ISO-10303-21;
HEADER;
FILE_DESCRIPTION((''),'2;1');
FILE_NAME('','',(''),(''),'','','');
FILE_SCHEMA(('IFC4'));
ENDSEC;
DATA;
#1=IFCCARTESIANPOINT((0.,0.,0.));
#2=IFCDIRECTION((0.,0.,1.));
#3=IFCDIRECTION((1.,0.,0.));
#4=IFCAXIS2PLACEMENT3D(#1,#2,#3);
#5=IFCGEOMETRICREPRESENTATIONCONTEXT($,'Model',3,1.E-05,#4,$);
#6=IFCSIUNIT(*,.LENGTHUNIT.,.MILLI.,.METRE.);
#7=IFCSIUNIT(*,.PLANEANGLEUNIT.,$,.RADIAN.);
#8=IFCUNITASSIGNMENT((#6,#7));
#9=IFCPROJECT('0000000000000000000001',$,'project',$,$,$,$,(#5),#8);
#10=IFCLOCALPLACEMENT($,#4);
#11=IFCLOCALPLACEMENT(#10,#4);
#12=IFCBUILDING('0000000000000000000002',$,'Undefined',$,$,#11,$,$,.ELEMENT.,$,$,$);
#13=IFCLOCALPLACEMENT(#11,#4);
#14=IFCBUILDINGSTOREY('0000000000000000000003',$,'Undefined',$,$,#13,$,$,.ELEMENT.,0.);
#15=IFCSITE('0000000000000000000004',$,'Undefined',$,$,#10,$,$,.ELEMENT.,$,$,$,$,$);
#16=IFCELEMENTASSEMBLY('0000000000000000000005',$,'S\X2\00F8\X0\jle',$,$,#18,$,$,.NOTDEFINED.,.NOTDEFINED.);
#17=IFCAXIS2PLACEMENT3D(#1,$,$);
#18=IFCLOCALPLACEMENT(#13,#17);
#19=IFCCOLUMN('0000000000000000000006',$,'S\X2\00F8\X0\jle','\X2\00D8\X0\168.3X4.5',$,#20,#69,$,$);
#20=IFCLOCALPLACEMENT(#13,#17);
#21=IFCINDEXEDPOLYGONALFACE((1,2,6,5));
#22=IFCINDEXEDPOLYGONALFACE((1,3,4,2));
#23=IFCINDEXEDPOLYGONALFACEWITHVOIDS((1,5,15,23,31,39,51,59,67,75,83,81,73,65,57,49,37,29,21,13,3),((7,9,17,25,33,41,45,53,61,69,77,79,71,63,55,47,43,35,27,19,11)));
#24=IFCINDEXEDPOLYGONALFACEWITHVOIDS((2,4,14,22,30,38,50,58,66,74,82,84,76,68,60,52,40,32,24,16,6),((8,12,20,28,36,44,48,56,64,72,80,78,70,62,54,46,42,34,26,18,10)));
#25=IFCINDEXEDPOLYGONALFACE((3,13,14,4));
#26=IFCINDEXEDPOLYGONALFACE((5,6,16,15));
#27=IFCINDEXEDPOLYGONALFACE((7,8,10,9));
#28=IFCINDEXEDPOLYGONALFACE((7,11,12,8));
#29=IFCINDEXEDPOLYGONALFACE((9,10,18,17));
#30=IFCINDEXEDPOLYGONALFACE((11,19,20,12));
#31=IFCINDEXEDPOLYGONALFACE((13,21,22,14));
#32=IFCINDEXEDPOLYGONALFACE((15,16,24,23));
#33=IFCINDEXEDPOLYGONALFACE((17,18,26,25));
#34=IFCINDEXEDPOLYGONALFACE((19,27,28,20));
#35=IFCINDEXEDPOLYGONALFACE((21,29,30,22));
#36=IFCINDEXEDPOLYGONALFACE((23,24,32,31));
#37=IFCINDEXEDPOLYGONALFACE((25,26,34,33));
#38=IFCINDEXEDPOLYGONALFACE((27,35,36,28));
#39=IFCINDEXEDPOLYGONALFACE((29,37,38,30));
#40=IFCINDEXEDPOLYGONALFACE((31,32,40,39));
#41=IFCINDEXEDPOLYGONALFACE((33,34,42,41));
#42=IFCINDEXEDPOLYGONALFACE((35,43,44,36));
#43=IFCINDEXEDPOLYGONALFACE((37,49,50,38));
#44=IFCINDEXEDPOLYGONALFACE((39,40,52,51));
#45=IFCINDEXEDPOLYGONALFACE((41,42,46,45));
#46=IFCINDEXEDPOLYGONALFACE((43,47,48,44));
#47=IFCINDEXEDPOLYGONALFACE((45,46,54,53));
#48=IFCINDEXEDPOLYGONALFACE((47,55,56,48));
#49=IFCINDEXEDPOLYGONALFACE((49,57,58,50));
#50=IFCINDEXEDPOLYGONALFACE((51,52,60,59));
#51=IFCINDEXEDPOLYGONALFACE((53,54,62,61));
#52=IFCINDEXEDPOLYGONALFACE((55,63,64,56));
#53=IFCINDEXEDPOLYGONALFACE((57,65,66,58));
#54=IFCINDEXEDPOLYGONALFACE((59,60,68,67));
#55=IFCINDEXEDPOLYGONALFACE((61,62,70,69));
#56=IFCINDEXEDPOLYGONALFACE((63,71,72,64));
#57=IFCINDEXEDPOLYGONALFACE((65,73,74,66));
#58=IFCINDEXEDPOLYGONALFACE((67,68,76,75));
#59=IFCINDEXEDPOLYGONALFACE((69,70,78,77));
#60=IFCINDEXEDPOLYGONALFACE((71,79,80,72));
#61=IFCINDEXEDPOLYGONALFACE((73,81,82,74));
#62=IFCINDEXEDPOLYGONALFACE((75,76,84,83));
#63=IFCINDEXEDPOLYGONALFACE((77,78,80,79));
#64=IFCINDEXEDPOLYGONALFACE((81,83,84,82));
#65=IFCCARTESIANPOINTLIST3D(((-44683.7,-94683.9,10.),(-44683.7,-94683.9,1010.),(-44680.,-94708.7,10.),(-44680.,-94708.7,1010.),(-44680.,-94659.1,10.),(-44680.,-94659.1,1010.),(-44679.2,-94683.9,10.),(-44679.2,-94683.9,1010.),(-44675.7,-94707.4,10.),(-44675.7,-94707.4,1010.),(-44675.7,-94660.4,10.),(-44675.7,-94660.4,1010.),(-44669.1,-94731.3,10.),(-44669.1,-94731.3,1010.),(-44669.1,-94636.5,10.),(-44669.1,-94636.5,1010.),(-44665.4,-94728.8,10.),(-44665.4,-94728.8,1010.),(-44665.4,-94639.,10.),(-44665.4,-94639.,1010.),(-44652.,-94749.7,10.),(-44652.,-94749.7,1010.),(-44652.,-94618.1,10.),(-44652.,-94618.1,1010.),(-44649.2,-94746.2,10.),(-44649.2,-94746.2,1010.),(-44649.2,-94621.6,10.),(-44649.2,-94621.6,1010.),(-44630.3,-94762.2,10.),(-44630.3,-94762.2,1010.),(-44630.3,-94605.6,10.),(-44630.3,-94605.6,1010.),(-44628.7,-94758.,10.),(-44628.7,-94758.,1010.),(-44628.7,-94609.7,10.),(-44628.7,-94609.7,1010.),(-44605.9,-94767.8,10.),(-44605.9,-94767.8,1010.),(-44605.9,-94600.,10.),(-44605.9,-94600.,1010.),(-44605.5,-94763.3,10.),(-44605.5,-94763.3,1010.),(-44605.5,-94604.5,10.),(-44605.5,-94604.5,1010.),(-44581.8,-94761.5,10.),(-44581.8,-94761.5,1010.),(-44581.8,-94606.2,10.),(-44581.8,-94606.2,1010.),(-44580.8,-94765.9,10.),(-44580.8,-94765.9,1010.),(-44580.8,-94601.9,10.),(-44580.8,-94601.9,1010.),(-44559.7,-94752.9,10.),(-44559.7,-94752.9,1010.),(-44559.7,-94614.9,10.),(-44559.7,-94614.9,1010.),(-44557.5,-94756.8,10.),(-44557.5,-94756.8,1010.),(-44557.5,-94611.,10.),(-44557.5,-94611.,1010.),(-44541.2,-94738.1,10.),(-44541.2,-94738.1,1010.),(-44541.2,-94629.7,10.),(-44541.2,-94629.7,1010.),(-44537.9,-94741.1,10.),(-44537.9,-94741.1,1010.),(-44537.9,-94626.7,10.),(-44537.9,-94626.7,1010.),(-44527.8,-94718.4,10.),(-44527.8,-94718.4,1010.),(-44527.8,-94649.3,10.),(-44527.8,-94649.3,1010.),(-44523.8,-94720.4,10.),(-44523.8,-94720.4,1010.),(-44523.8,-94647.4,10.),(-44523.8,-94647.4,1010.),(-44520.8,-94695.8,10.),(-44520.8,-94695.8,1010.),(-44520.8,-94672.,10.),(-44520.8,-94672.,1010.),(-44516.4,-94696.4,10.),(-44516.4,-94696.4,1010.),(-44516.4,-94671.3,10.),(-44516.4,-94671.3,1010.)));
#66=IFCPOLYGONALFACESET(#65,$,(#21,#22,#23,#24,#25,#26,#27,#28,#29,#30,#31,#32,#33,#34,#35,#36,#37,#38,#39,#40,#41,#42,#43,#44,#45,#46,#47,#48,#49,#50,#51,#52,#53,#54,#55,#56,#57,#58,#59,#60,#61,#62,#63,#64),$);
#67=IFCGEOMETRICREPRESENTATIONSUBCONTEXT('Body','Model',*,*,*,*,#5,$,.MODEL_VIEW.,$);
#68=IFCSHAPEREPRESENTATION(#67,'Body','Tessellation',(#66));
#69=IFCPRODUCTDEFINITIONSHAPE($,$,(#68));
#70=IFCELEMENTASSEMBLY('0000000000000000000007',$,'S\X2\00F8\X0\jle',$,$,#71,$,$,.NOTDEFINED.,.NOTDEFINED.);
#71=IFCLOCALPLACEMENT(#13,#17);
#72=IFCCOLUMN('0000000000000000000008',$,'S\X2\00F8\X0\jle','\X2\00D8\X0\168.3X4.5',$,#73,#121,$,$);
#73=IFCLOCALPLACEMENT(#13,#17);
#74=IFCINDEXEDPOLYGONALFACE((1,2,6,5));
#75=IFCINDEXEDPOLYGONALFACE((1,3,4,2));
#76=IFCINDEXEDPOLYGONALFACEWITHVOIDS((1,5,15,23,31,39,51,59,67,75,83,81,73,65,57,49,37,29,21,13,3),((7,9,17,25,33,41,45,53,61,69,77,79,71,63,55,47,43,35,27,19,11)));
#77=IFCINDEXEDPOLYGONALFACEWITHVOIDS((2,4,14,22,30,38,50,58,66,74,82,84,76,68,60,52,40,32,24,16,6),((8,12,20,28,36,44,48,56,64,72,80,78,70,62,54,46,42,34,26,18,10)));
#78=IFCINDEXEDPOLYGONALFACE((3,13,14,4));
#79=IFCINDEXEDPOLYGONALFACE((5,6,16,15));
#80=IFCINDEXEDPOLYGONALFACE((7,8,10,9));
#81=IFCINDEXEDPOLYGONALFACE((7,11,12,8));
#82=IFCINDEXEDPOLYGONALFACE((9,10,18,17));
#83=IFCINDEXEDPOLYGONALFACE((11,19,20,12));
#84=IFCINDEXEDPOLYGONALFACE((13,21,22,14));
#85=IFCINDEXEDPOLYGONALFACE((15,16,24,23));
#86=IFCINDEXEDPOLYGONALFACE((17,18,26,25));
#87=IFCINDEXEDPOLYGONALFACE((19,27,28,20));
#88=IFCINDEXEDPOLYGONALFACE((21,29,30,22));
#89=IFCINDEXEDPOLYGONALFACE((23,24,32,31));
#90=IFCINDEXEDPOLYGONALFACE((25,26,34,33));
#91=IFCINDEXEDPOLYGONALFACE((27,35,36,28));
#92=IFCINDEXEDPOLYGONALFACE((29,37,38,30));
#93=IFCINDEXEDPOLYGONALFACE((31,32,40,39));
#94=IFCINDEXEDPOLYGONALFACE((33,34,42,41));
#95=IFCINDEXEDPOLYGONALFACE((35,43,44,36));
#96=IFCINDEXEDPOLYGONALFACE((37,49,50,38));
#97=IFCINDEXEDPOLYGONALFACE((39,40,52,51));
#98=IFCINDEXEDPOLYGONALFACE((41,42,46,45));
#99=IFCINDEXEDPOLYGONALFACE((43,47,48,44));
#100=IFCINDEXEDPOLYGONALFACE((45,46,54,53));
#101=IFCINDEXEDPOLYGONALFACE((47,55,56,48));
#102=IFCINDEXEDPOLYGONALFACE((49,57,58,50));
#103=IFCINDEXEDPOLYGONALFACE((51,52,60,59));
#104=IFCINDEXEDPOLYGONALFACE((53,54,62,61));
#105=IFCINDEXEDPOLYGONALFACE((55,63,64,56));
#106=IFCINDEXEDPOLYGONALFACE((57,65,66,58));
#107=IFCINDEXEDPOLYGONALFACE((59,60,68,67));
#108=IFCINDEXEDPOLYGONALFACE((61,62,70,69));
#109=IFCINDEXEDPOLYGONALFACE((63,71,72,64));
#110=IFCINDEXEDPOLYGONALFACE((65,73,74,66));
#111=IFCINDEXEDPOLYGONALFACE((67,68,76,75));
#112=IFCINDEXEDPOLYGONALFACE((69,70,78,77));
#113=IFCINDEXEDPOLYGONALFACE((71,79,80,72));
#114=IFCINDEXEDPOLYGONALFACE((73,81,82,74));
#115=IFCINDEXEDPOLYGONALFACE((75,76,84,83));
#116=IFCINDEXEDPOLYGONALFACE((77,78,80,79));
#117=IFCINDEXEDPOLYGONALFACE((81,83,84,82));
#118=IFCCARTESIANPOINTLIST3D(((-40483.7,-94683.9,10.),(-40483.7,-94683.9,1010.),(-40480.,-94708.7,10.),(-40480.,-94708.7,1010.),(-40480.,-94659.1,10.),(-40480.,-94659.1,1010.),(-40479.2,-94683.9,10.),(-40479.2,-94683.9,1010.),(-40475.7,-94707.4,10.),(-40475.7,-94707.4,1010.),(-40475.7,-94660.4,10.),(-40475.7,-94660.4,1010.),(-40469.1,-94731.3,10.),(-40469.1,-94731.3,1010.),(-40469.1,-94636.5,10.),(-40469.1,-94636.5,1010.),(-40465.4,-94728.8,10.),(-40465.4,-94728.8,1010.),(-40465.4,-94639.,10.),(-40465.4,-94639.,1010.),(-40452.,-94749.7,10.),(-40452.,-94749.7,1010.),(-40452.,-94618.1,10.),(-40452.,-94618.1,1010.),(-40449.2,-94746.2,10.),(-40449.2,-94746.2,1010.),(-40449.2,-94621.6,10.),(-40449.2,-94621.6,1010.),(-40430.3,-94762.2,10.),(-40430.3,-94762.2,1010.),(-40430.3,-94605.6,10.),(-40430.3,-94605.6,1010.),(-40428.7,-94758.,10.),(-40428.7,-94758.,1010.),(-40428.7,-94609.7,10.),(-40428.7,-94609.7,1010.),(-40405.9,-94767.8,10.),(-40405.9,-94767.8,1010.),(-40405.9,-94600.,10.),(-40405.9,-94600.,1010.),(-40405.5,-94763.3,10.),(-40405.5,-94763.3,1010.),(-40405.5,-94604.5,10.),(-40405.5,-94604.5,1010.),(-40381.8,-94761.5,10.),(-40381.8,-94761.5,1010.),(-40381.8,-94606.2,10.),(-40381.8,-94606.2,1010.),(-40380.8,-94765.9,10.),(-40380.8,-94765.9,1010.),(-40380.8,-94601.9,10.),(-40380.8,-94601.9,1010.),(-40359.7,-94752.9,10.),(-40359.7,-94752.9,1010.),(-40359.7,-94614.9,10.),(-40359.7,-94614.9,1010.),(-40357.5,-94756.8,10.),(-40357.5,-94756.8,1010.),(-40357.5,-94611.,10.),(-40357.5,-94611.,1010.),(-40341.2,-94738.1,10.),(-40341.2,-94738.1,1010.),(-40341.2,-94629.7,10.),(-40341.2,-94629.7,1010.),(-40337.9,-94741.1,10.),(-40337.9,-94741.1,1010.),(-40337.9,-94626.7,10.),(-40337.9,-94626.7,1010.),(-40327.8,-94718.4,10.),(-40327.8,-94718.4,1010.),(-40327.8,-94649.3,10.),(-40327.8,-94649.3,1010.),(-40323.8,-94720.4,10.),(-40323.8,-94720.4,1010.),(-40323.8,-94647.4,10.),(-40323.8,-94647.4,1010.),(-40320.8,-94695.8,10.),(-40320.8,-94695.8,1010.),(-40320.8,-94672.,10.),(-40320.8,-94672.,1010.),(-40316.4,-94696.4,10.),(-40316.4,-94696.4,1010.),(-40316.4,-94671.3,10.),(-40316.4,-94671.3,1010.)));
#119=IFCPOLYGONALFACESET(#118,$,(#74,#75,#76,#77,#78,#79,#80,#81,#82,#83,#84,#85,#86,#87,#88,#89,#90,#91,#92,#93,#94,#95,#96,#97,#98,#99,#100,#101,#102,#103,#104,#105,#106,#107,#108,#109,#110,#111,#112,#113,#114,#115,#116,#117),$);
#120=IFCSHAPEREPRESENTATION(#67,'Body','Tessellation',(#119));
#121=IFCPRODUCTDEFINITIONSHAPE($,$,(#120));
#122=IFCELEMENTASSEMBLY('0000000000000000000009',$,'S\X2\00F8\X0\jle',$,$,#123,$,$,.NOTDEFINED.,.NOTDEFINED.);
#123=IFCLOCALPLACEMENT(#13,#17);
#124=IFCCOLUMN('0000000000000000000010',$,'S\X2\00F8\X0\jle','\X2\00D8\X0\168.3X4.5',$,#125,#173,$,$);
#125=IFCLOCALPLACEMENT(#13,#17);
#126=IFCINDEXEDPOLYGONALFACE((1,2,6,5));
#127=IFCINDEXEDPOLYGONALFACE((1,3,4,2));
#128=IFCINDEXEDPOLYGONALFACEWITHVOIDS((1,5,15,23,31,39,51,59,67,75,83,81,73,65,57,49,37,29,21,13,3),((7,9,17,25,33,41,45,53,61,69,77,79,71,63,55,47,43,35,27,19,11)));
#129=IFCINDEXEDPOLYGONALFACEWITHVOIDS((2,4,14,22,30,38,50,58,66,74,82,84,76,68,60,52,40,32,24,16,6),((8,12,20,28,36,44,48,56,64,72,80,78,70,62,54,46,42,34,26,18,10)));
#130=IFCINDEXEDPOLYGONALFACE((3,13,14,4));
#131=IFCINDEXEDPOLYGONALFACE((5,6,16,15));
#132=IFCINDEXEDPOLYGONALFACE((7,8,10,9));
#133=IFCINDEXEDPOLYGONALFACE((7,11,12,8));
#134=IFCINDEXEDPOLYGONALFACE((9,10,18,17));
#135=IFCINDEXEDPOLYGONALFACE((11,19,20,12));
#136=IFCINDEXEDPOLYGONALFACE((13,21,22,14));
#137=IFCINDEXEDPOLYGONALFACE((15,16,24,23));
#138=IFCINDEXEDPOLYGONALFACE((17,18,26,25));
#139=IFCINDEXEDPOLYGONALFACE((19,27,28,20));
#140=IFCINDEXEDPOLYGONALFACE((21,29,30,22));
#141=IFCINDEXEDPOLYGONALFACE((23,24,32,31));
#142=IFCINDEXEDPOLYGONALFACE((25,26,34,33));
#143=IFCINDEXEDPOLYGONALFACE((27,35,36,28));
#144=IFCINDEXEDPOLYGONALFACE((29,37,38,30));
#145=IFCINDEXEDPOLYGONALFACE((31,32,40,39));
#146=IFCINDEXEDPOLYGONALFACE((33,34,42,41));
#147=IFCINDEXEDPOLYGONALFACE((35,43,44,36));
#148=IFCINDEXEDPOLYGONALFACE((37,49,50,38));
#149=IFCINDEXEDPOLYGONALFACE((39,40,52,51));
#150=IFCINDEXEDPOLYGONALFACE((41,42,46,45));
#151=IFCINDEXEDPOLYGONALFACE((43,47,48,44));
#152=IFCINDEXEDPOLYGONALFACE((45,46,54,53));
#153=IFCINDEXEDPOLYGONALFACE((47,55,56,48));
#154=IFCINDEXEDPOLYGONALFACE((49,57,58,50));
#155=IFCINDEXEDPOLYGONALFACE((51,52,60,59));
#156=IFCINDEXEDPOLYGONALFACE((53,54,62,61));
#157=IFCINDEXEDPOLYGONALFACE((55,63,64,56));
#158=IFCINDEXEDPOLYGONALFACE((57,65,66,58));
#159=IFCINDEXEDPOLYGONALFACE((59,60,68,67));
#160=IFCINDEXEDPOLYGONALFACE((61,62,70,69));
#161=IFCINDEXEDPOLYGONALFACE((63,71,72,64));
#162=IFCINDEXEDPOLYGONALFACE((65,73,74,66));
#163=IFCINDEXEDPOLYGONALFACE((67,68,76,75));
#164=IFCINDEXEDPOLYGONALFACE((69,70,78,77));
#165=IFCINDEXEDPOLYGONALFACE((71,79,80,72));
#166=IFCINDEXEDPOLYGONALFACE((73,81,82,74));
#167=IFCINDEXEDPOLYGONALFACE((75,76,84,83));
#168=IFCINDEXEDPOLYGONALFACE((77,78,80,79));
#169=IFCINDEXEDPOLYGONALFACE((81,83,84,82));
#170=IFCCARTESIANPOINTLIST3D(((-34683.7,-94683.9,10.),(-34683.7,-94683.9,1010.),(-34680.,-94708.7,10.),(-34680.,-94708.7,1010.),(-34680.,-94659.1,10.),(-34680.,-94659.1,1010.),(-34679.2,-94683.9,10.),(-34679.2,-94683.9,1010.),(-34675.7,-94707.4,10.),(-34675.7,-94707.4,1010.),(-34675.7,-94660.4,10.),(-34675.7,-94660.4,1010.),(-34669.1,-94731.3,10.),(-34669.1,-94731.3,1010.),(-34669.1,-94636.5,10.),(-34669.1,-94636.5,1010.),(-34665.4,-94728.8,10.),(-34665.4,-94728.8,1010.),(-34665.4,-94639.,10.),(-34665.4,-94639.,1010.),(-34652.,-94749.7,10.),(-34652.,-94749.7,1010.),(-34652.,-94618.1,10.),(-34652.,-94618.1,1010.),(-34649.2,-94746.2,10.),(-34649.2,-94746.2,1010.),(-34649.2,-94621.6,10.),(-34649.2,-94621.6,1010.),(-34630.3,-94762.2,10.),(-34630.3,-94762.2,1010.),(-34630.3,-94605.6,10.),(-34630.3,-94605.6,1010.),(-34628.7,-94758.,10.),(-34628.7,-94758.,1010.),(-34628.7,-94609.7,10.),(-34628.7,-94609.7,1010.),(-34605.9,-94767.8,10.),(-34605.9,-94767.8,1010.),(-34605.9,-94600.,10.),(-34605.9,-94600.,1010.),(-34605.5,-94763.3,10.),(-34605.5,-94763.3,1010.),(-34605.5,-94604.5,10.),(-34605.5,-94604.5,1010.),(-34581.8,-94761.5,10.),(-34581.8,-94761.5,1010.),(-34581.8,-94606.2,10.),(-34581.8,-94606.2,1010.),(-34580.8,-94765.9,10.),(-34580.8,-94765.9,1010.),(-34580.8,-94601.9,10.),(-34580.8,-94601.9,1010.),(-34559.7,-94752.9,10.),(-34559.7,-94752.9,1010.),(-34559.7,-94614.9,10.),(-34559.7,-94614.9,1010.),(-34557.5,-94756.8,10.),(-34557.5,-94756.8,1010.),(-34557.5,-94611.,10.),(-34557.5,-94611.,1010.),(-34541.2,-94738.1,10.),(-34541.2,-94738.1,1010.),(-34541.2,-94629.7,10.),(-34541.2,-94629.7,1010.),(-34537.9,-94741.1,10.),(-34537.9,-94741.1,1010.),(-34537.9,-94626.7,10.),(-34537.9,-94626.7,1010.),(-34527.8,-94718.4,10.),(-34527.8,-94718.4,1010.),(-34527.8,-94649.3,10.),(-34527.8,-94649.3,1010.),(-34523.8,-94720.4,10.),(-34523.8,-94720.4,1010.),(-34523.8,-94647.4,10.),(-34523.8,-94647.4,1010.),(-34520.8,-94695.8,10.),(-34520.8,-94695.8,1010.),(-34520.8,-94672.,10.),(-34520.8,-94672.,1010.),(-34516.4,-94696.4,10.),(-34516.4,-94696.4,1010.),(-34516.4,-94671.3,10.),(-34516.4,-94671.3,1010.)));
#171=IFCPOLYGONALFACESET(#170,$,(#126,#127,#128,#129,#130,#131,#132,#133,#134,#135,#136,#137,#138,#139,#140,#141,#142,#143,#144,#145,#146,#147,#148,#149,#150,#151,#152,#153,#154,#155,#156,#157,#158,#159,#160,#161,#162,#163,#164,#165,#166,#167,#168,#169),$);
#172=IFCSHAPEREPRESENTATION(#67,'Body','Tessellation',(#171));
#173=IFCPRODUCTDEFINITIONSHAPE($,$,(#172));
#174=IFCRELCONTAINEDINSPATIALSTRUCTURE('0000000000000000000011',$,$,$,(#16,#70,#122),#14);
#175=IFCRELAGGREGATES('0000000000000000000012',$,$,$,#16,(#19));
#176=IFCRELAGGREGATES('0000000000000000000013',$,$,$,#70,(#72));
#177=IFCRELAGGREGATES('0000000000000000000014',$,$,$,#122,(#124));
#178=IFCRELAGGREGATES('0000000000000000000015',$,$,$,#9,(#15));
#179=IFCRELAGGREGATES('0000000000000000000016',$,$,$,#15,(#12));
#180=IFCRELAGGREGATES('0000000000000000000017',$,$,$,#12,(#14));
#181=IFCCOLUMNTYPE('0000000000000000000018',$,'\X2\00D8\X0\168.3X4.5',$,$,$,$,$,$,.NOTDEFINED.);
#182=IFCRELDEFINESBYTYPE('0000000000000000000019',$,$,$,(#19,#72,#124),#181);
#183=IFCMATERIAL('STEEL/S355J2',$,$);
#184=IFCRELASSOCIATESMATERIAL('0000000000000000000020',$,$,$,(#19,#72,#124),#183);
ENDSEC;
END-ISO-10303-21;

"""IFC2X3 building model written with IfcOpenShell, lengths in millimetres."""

from ifc_helpers import new_model, si_unit, frame, origin_with_axes, origin_2d_with_axis, place, context, subcontext, project, spatial, hollow_circle, extrude, clip, halfspace, material, type_object, element, aggregate, save


model = new_model("IFC2X3")

# Units and contexts
model_context = context("Model", 3, precision=1e-05, world=origin_with_axes())
body_context = subcontext(model_context, "Body", "Model", "MODEL_VIEW")
ifc_project = project(units=[si_unit("LENGTHUNIT", "METRE", prefix="MILLI"), si_unit("PLANEANGLEUNIT", "RADIAN")], contexts=[model_context])

# Site, building, storey
site_placement = place(None, origin_with_axes())
site = spatial("IfcSite", under=ifc_project, at=site_placement, Name="Undefined", CompositionType="ELEMENT")
building_placement = place(site_placement, origin_with_axes())
building = spatial("IfcBuilding", under=site, at=building_placement, Name="Undefined", CompositionType="ELEMENT")
storey_placement = place(building_placement, origin_with_axes())
storey = spatial("IfcBuildingStorey", under=building, at=storey_placement, Name="Undefined", CompositionType="ELEMENT", Elevation=0.0)

# Element assemblies, columns
assembly_1_placement = place(storey_placement, origin_with_axes())
assembly_1 = element("IfcElementAssembly", 1, at=assembly_1_placement, inside=storey, Name="Søjle", AssemblyPlace="NOTDEFINED", PredefinedType="NOTDEFINED")
ifc_material_1 = material(Name="STEEL/S355J2")
column_type = type_object("IfcColumnType", Name="Ø168.3X4.5", PredefinedType="NOTDEFINED")
column_1_placement = place(assembly_1_placement, frame((-44599.6, -94683.9, 0.0), z_axis=(0.0, 0.0, 1.0), x_axis=(0.0, 1.0, 0.0)))
column_1 = element("IfcColumn", 2, at=column_1_placement, type_object=column_type, material=ifc_material_1, Name="Søjle", Description="Ø168.3X4.5", context=body_context, shape_type="Clipping", body=[
    clip(clip(extrude(hollow_circle(Radius=84.2, WallThickness=4.5, at=origin_2d_with_axis()), frame((0.0, 0.0, 1010.0), z_axis=(0.0, 0.0, -1.0), x_axis=(0.0, 1.0, 0.0)), (0.0, 0.0, 1.0), 1010.0), halfspace(frame((-84.1, 0.0, 1010.0), z_axis=(0.0, 0.0, -1.0), x_axis=(0.0, -1.0, 0.0)), True)), halfspace(frame((-84.1, 0.0, 10.0), z_axis=(0.0, 0.0, 1.0), x_axis=(0.0, 1.0, 0.0)), True)),
])
assembly_2_placement = place(storey_placement, origin_with_axes())
assembly_2 = element("IfcElementAssembly", 3, at=assembly_2_placement, inside=storey, Name="Søjle", AssemblyPlace="NOTDEFINED", PredefinedType="NOTDEFINED")
column_2_placement = place(assembly_2_placement, frame((-40399.6, -94683.9, 0.0), z_axis=(0.0, 0.0, 1.0), x_axis=(0.0, 1.0, 0.0)))
column_2 = element("IfcColumn", 4, at=column_2_placement, type_object=column_type, material=ifc_material_1, Name="Søjle", Description="Ø168.3X4.5", context=body_context, shape_type="Clipping", body=[
    clip(clip(extrude(hollow_circle(Radius=84.2, WallThickness=4.5, at=origin_2d_with_axis()), frame((0.0, 0.0, 1010.0), z_axis=(0.0, 0.0, -1.0), x_axis=(0.0, 1.0, 0.0)), (0.0, 0.0, 1.0), 1010.0), halfspace(frame((-84.1, 0.0, 1010.0), z_axis=(0.0, 0.0, -1.0), x_axis=(0.0, -1.0, 0.0)), True)), halfspace(frame((-84.1, 0.0, 10.0), z_axis=(0.0, 0.0, 1.0), x_axis=(0.0, 1.0, 0.0)), True)),
])
assembly_3_placement = place(storey_placement, origin_with_axes())
assembly_3 = element("IfcElementAssembly", 5, at=assembly_3_placement, inside=storey, Name="Søjle", AssemblyPlace="NOTDEFINED", PredefinedType="NOTDEFINED")
column_3_placement = place(assembly_3_placement, frame((-34599.6, -94683.9, 0.0), z_axis=(0.0, 0.0, 1.0), x_axis=(0.0, 1.0, 0.0)))
column_3 = element("IfcColumn", 6, at=column_3_placement, type_object=column_type, material=ifc_material_1, Name="Søjle", Description="Ø168.3X4.5", context=body_context, shape_type="Clipping", body=[
    clip(clip(extrude(hollow_circle(Radius=84.2, WallThickness=4.5, at=origin_2d_with_axis()), frame((0.0, 0.0, 1010.0), z_axis=(0.0, 0.0, -1.0), x_axis=(0.0, 1.0, 0.0)), (0.0, 0.0, 1.0), 1010.0), halfspace(frame((-84.1, 0.0, 1010.0), z_axis=(0.0, 0.0, -1.0), x_axis=(0.0, -1.0, 0.0)), True)), halfspace(frame((-84.1, 0.0, 10.0), z_axis=(0.0, 0.0, 1.0), x_axis=(0.0, 1.0, 0.0)), True)),
])

aggregate(assembly_1, [column_1])
aggregate(assembly_2, [column_2])
aggregate(assembly_3, [column_3])

save(model, "model.ifc")
